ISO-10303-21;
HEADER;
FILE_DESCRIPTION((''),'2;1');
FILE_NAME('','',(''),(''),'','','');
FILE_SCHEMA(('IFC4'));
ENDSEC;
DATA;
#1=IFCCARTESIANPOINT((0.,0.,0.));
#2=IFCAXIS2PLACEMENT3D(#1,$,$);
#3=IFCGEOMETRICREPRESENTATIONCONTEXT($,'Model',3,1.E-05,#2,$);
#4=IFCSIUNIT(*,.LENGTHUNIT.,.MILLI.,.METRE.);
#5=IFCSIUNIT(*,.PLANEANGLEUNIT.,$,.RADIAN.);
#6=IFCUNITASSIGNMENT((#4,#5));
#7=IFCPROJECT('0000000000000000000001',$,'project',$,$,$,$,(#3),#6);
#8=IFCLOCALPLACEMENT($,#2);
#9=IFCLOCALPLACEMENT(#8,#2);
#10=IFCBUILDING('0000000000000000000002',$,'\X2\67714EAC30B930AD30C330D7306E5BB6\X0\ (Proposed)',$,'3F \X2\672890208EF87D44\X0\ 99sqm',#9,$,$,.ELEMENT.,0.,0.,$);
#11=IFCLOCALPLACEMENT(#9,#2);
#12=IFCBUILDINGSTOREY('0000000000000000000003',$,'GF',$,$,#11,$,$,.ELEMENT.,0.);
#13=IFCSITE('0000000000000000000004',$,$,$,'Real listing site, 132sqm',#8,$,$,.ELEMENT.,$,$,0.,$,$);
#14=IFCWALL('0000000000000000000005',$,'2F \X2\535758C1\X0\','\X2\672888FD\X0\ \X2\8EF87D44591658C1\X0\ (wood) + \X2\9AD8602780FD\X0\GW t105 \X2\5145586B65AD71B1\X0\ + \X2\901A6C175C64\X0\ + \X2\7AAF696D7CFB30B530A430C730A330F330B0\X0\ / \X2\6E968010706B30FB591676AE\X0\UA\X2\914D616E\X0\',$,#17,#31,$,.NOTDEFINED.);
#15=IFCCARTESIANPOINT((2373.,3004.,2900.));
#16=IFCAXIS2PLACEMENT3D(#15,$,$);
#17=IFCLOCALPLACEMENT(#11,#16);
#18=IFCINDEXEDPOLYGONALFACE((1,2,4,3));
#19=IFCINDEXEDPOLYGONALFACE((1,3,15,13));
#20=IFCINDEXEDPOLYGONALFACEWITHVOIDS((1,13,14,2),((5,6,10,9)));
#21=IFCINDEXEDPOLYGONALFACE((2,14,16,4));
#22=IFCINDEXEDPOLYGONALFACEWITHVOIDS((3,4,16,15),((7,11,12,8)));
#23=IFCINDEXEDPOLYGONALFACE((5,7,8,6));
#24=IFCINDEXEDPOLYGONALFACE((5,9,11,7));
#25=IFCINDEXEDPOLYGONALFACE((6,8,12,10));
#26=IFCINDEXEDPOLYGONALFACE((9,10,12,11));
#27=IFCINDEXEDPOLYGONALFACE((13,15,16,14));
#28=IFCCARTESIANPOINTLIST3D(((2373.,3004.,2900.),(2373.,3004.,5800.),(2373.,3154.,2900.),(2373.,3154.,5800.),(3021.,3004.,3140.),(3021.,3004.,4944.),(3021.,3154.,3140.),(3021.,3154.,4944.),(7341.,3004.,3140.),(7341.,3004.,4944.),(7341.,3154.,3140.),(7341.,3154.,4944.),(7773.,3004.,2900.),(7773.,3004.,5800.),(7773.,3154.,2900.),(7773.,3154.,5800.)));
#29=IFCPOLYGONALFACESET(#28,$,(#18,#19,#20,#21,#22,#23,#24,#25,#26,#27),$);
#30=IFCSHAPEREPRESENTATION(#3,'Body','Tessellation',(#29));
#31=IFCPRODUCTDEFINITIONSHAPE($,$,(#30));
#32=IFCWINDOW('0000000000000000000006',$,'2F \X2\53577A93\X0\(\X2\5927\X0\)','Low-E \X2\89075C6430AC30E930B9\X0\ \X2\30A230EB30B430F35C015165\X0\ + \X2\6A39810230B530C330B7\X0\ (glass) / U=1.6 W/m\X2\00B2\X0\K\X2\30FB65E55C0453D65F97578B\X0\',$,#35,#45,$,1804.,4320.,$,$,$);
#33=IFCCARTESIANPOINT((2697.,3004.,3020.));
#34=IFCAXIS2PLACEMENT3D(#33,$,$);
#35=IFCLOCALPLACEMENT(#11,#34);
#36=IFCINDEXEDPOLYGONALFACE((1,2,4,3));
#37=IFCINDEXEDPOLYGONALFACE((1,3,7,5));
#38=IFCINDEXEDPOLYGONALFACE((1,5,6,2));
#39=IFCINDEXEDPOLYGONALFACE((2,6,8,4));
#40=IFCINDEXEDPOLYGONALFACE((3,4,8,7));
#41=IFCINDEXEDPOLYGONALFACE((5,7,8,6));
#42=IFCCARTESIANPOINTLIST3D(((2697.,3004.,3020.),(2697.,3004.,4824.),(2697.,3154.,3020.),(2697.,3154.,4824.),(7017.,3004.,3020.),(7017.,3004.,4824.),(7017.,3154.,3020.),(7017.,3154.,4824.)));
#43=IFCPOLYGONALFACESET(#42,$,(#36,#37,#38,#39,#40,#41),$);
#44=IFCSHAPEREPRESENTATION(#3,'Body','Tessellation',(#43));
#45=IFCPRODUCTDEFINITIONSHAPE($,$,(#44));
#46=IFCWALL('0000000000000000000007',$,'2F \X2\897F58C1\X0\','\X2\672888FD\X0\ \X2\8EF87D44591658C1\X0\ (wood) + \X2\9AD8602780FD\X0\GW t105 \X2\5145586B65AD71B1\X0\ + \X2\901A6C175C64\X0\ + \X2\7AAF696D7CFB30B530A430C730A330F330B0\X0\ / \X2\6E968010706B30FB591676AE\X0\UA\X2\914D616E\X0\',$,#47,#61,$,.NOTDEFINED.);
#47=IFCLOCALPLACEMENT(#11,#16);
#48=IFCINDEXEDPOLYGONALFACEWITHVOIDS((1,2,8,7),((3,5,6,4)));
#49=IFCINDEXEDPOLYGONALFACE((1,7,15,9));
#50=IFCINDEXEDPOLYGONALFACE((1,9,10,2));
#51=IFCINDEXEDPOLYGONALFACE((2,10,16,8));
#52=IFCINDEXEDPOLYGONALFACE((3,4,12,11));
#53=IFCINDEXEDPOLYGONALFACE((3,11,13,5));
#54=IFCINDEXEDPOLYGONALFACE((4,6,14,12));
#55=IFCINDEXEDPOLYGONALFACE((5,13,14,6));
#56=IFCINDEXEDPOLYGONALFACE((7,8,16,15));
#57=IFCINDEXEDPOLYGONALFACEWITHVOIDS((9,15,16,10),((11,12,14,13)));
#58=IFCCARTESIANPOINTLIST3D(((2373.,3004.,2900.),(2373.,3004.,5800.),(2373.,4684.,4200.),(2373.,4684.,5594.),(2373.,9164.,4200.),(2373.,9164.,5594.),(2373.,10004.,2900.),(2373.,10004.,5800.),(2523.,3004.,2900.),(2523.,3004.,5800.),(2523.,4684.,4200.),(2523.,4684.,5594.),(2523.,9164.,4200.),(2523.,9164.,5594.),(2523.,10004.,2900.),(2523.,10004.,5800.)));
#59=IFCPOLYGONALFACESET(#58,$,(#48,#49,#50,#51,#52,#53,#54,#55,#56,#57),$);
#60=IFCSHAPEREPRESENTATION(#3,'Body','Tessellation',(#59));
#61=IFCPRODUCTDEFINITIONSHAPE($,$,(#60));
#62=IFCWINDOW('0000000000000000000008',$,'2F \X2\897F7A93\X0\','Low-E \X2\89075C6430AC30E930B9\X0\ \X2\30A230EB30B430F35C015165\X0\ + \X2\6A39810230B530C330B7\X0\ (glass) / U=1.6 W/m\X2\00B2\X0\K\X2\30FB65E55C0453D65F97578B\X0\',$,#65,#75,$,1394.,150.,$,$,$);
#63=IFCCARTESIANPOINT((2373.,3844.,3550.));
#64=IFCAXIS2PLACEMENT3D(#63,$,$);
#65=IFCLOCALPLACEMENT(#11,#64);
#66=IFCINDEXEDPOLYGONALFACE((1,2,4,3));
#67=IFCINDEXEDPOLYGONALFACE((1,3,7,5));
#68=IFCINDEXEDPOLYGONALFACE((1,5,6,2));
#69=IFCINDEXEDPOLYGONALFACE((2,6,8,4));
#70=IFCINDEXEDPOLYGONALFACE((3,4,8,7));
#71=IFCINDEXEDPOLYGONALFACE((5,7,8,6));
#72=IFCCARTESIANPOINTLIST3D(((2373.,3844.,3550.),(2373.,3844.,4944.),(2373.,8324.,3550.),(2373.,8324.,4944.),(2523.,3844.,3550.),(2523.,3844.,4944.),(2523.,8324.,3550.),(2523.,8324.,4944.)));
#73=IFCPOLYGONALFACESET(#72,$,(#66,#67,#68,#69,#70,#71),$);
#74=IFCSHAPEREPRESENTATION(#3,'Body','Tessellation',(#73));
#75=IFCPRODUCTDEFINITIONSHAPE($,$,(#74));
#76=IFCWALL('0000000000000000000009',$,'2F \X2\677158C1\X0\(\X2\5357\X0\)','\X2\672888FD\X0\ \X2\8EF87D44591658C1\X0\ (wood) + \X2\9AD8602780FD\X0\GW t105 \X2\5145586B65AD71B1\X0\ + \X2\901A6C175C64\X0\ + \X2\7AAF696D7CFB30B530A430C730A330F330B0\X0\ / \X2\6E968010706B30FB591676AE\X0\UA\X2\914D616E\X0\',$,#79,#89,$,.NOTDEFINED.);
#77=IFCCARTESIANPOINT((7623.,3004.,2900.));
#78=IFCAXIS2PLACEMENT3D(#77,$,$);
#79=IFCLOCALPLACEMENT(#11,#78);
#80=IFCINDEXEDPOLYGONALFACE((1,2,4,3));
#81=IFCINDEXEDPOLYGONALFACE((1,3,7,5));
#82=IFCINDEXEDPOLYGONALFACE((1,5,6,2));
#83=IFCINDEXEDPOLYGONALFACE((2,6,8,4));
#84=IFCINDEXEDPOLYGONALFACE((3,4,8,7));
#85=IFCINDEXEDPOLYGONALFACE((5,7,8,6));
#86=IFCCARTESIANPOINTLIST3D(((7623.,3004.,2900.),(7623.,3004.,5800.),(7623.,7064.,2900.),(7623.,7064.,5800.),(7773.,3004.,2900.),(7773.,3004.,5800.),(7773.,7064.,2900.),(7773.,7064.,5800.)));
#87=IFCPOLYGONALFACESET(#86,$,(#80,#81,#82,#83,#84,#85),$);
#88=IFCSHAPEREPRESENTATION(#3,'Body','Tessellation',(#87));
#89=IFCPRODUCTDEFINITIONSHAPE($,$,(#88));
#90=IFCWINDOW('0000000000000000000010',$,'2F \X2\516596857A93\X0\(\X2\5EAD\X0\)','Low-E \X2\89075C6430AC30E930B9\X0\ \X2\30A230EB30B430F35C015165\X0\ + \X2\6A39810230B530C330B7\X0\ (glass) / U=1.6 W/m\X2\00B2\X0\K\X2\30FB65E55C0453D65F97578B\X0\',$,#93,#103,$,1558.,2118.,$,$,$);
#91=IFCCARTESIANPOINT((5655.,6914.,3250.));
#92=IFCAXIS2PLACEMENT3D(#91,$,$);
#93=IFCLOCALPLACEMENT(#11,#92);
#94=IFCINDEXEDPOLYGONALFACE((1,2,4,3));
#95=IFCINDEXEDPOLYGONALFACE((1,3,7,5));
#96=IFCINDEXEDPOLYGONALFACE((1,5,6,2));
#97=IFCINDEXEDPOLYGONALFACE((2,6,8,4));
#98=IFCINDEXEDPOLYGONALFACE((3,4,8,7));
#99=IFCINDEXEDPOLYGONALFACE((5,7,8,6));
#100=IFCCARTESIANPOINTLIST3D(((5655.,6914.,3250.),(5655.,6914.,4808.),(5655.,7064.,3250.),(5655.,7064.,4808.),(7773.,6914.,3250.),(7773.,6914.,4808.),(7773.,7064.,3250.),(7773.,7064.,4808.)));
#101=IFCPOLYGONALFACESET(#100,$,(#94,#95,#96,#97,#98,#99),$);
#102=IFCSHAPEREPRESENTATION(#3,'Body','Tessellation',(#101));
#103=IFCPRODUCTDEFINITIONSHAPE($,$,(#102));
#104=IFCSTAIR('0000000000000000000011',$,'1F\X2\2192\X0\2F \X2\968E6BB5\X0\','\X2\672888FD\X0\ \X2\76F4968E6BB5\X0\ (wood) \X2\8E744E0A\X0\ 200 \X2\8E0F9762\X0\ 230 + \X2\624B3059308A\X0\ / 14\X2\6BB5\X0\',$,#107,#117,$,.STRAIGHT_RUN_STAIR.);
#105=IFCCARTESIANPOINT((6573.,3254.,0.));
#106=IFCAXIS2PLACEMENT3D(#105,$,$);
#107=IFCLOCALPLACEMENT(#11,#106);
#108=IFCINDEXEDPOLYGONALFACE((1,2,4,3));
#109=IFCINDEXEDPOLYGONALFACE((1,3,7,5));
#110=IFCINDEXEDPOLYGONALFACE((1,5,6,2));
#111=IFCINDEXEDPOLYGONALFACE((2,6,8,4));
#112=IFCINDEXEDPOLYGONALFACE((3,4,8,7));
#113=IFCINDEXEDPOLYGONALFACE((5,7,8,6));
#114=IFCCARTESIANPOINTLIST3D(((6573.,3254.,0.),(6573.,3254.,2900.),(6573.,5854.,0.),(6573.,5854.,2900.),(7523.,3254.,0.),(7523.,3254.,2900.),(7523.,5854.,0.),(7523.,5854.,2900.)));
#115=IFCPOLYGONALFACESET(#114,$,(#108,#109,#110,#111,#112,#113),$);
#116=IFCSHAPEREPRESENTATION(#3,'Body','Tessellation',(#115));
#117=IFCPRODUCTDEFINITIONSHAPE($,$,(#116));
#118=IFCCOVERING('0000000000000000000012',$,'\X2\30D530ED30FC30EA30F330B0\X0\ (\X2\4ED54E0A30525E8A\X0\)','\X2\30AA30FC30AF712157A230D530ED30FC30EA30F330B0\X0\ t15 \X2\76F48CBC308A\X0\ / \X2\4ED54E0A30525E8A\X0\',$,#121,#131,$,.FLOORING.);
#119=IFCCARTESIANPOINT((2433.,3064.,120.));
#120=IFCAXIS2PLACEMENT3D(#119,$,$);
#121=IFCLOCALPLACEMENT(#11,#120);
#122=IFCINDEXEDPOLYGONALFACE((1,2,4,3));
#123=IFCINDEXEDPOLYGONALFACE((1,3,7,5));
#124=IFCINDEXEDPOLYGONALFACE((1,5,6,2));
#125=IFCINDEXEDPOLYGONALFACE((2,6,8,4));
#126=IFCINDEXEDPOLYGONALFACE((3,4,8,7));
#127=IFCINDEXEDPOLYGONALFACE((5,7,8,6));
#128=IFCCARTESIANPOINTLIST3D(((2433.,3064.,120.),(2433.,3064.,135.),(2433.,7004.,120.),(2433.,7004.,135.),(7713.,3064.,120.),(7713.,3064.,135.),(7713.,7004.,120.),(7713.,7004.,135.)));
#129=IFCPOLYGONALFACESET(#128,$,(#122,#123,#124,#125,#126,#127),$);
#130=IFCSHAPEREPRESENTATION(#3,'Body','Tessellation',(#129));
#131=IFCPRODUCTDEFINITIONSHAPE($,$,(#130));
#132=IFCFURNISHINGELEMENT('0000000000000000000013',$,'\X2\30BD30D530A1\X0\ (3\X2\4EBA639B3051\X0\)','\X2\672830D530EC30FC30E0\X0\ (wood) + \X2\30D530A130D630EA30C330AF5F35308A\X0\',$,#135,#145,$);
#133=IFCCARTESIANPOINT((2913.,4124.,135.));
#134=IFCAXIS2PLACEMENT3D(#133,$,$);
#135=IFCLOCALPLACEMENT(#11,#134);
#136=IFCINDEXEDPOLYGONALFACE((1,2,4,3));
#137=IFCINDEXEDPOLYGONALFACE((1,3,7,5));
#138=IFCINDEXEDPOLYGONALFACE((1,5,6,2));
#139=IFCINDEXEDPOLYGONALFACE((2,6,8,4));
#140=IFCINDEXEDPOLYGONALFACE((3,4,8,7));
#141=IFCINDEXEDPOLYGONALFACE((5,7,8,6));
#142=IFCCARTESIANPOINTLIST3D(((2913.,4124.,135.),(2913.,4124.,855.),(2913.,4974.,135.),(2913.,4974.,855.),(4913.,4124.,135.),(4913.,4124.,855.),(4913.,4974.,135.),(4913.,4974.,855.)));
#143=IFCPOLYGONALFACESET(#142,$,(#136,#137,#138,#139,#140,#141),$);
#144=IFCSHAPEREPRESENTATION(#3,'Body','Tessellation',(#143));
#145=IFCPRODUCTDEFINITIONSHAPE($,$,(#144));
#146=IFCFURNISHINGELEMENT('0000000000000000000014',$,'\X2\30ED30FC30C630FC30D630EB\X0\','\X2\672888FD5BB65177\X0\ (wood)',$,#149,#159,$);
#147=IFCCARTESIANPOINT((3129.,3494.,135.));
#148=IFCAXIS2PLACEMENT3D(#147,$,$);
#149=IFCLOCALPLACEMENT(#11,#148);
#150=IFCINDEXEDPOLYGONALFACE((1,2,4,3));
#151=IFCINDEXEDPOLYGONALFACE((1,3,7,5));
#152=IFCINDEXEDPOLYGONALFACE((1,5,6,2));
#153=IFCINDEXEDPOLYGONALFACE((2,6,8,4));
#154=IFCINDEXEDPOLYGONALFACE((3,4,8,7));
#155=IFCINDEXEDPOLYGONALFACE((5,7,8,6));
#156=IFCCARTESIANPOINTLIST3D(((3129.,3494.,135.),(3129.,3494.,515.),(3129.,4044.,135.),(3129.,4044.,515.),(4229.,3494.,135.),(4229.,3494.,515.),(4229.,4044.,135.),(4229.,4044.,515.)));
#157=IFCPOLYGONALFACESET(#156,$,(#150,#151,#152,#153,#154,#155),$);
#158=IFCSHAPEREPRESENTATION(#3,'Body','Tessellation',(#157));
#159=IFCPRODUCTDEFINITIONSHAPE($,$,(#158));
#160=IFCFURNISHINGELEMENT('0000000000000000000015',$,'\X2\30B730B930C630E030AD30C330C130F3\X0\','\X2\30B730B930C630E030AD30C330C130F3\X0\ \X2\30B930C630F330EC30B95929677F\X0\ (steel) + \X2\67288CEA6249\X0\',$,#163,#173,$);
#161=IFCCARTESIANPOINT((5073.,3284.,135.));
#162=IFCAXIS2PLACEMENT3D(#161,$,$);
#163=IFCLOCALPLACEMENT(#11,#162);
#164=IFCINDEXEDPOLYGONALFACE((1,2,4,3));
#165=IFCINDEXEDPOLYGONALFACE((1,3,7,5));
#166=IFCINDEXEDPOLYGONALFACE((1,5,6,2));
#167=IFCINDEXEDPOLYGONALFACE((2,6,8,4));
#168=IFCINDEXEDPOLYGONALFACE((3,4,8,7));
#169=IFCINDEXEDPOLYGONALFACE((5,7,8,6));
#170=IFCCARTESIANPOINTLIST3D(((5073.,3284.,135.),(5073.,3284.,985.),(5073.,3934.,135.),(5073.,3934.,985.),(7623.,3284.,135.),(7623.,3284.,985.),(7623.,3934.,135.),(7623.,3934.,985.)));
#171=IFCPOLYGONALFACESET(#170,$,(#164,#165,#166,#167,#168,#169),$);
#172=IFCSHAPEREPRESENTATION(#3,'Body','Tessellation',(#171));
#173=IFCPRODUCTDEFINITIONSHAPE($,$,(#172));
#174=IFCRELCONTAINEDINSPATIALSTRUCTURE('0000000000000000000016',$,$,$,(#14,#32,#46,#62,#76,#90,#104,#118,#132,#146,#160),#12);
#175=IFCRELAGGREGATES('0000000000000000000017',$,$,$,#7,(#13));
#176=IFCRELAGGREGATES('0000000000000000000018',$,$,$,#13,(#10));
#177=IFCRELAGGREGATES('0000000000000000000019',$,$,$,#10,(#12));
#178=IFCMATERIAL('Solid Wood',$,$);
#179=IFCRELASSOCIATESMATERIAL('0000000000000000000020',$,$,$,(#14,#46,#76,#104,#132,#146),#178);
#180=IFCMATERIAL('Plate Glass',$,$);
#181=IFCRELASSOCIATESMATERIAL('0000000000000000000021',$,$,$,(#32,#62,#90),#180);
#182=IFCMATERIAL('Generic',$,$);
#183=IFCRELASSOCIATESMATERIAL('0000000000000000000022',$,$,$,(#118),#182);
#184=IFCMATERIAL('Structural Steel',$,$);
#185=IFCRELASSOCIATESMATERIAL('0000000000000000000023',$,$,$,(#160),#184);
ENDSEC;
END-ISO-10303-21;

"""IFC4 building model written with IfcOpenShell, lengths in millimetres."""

from ifc_helpers import new_model, si_unit, frame, frame_2d, origin, place, context, project, spatial, rectangle, extrude, material, element, fill, save


model = new_model("IFC4")

# Units and contexts
model_context = context("Model", 3, precision=1e-05, world=origin())
ifc_project = project(units=[si_unit("LENGTHUNIT", "METRE", prefix="MILLI"), si_unit("PLANEANGLEUNIT", "RADIAN")], contexts=[model_context])

# Site, building, storey
site_placement = place(None, origin())
site = spatial("IfcSite", under=ifc_project, at=site_placement, ObjectType="Real listing site, 132sqm", CompositionType="ELEMENT", RefElevation=0.0)
building_placement = place(site_placement, origin())
building = spatial("IfcBuilding", under=site, at=building_placement, Name="東京スキップの家 (Proposed)", ObjectType="3F 木造軸組 99sqm", CompositionType="ELEMENT", ElevationOfRefHeight=0.0, ElevationOfTerrain=0.0)
storey_placement = place(building_placement, origin())
storey = spatial("IfcBuildingStorey", under=building, at=storey_placement, Name="GF", CompositionType="ELEMENT", Elevation=0.0)

# Shared definitions
ifc_material_1 = material(Name="Solid Wood")

# Shared definitions
ifc_material_2 = material(Name="Plate Glass")

# Walls, openings, windows
wall_1_placement = place(storey_placement, frame((2373.0, 3004.0, 2900.0)))
wall_1 = element("IfcWall", 1, at=wall_1_placement, inside=storey, material=ifc_material_1, Name="2F 南壁", Description="木製 軸組外壁 (wood) + 高性能GW t105 充填断熱 + 通気層 + 窯業系サイディング / 準耐火・外皮UA配慮", PredefinedType="NOTDEFINED", context=model_context, shape_type="SweptSolid", body=[
    extrude(rectangle(XDim=5400.0, YDim=150.0, at=frame_2d((2700.0, 75.0))), frame((2373.0, 3004.0, 2900.0)), (0.0, 0.0, 1.0), 2900.0),
])
opening_1_placement = place(storey_placement, frame((2697.0, 3004.0, 3020.0)))
opening_1 = element("IfcOpeningElement", 2, at=opening_1_placement, cuts=wall_1, PredefinedType="NOTDEFINED", context=model_context, shape_type="SweptSolid", body=[
    extrude(rectangle(XDim=4320.0, YDim=150.0, at=frame_2d((2160.0, 75.0))), frame((2697.0, 3004.0, 3020.0)), (0.0, 0.0, 1.0), 1804.0),
])
window_1_placement = place(storey_placement, frame((2697.0, 3004.0, 3020.0)))
window_1 = element("IfcWindow", 3, at=window_1_placement, inside=storey, material=ifc_material_2, Name="2F 南窓(大)", Description="Low-E 複層ガラス アルゴン封入 + 樹脂サッシ (glass) / U=1.6 W/m²K・日射取得型", OverallHeight=1804.0, OverallWidth=4320.0, context=model_context, shape_type="SweptSolid", body=[
    extrude(rectangle(XDim=4320.0, YDim=150.0, at=frame_2d((2160.0, 75.0))), frame((2697.0, 3004.0, 3020.0)), (0.0, 0.0, 1.0), 1804.0),
])
fill(opening_1, window_1)
wall_2_placement = place(storey_placement, frame((2373.0, 3004.0, 2900.0)))
wall_2 = element("IfcWall", 4, at=wall_2_placement, inside=storey, material=ifc_material_1, Name="2F 西壁", Description="木製 軸組外壁 (wood) + 高性能GW t105 充填断熱 + 通気層 + 窯業系サイディング / 準耐火・外皮UA配慮", PredefinedType="NOTDEFINED", context=model_context, shape_type="SweptSolid", body=[
    extrude(rectangle(XDim=150.0, YDim=7000.0, at=frame_2d((75.0, 3500.0))), frame((2373.0, 3004.0, 2900.0)), (0.0, 0.0, 1.0), 2900.0),
])
opening_2_placement = place(storey_placement, frame((2373.0, 3844.0, 3550.0)))
opening_2 = element("IfcOpeningElement", 5, at=opening_2_placement, cuts=wall_2, PredefinedType="NOTDEFINED", context=model_context, shape_type="SweptSolid", body=[
    extrude(rectangle(XDim=150.0, YDim=4480.0, at=frame_2d((75.0, 2240.0))), frame((2373.0, 3844.0, 3550.0)), (0.0, 0.0, 1.0), 1394.0),
])
window_2_placement = place(storey_placement, frame((2373.0, 3844.0, 3550.0)))
window_2 = element("IfcWindow", 6, at=window_2_placement, inside=storey, material=ifc_material_2, Name="2F 西窓", Description="Low-E 複層ガラス アルゴン封入 + 樹脂サッシ (glass) / U=1.6 W/m²K・日射取得型", OverallHeight=1394.0, OverallWidth=150.0, context=model_context, shape_type="SweptSolid", body=[
    extrude(rectangle(XDim=150.0, YDim=4480.0, at=frame_2d((75.0, 2240.0))), frame((2373.0, 3844.0, 3550.0)), (0.0, 0.0, 1.0), 1394.0),
])
fill(opening_2, window_2)
wall_3_placement = place(storey_placement, frame((7623.0, 3004.0, 2900.0)))
wall_3 = element("IfcWall", 7, at=wall_3_placement, inside=storey, material=ifc_material_1, Name="2F 東壁(南)", Description="木製 軸組外壁 (wood) + 高性能GW t105 充填断熱 + 通気層 + 窯業系サイディング / 準耐火・外皮UA配慮", PredefinedType="NOTDEFINED", context=model_context, shape_type="SweptSolid", body=[
    extrude(rectangle(XDim=150.0, YDim=4060.0, at=frame_2d((75.0, 2030.0))), frame((7623.0, 3004.0, 2900.0)), (0.0, 0.0, 1.0), 2900.0),
])
opening_3_placement = place(storey_placement, frame((5655.0, 6914.0, 3250.0)))
opening_3 = element("IfcOpeningElement", 8, at=opening_3_placement, cuts=wall_3, PredefinedType="NOTDEFINED", context=model_context, shape_type="SweptSolid", body=[
    extrude(rectangle(XDim=2118.0, YDim=150.0, at=frame_2d((1059.0, 75.0))), frame((5655.0, 6914.0, 3250.0)), (0.0, 0.0, 1.0), 1558.0),
])
window_3_placement = place(storey_placement, frame((5655.0, 6914.0, 3250.0)))
window_3 = element("IfcWindow", 9, at=window_3_placement, inside=storey, material=ifc_material_2, Name="2F 入隅窓(庭)", Description="Low-E 複層ガラス アルゴン封入 + 樹脂サッシ (glass) / U=1.6 W/m²K・日射取得型", OverallHeight=1558.0, OverallWidth=2118.0, context=model_context, shape_type="SweptSolid", body=[
    extrude(rectangle(XDim=2118.0, YDim=150.0, at=frame_2d((1059.0, 75.0))), frame((5655.0, 6914.0, 3250.0)), (0.0, 0.0, 1.0), 1558.0),
])
fill(opening_3, window_3)

# Stair
stair_placement = place(storey_placement, frame((6573.0, 3254.0, 0.0)))
element("IfcStair", 10, at=stair_placement, inside=storey, material=ifc_material_1, Name="1F→2F 階段", Description="木製 直階段 (wood) 蹴上 200 踏面 230 + 手すり / 14段", PredefinedType="STRAIGHT_RUN_STAIR", context=model_context, shape_type="SweptSolid", body=[
    extrude(rectangle(XDim=950.0, YDim=2600.0, at=frame_2d((475.0, 1300.0))), frame((6573.0, 3254.0, 0.0)), (0.0, 0.0, 1.0), 2900.0),
])

# Covering
ifc_material_3 = material(Name="Generic")
covering_placement = place(storey_placement, frame((2433.0, 3064.0, 120.0)))
element("IfcCovering", 11, at=covering_placement, inside=storey, material=ifc_material_3, Name="フローリング (仕上げ床)", Description="オーク無垢フローリング t15 直貼り / 仕上げ床", PredefinedType="FLOORING", context=model_context, shape_type="SweptSolid", body=[
    extrude(rectangle(XDim=5280.0, YDim=3940.0, at=frame_2d((2640.0, 1970.0))), frame((2433.0, 3064.0, 120.0)), (0.0, 0.0, 1.0), 15.0),
])

# Furnishing elements
furnishing_1_placement = place(storey_placement, frame((2913.0, 4124.0, 135.0)))
element("IfcFurnishingElement", 12, at=furnishing_1_placement, inside=storey, material=ifc_material_1, Name="ソファ (3人掛け)", Description="木フレーム (wood) + ファブリック張り", context=model_context, shape_type="SweptSolid", body=[
    extrude(rectangle(XDim=2000.0, YDim=850.0, at=frame_2d((1000.0, 425.0))), frame((2913.0, 4124.0, 135.0)), (0.0, 0.0, 1.0), 720.0),
])
furnishing_2_placement = place(storey_placement, frame((3129.0, 3494.0, 135.0)))
element("IfcFurnishingElement", 13, at=furnishing_2_placement, inside=storey, material=ifc_material_1, Name="ローテーブル", Description="木製家具 (wood)", context=model_context, shape_type="SweptSolid", body=[
    extrude(rectangle(XDim=1100.0, YDim=550.0, at=frame_2d((550.0, 275.0))), frame((3129.0, 3494.0, 135.0)), (0.0, 0.0, 1.0), 380.0),
])
ifc_material_4 = material(Name="Structural Steel")
furnishing_3_placement = place(storey_placement, frame((5073.0, 3284.0, 135.0)))
element("IfcFurnishingElement", 14, at=furnishing_3_placement, inside=storey, material=ifc_material_4, Name="システムキッチン", Description="システムキッチン ステンレス天板 (steel) + 木質扉", context=model_context, shape_type="SweptSolid", body=[
    extrude(rectangle(XDim=2550.0, YDim=650.0, at=frame_2d((1275.0, 325.0))), frame((5073.0, 3284.0, 135.0)), (0.0, 0.0, 1.0), 850.0),
])

save(model, "model.ifc")
